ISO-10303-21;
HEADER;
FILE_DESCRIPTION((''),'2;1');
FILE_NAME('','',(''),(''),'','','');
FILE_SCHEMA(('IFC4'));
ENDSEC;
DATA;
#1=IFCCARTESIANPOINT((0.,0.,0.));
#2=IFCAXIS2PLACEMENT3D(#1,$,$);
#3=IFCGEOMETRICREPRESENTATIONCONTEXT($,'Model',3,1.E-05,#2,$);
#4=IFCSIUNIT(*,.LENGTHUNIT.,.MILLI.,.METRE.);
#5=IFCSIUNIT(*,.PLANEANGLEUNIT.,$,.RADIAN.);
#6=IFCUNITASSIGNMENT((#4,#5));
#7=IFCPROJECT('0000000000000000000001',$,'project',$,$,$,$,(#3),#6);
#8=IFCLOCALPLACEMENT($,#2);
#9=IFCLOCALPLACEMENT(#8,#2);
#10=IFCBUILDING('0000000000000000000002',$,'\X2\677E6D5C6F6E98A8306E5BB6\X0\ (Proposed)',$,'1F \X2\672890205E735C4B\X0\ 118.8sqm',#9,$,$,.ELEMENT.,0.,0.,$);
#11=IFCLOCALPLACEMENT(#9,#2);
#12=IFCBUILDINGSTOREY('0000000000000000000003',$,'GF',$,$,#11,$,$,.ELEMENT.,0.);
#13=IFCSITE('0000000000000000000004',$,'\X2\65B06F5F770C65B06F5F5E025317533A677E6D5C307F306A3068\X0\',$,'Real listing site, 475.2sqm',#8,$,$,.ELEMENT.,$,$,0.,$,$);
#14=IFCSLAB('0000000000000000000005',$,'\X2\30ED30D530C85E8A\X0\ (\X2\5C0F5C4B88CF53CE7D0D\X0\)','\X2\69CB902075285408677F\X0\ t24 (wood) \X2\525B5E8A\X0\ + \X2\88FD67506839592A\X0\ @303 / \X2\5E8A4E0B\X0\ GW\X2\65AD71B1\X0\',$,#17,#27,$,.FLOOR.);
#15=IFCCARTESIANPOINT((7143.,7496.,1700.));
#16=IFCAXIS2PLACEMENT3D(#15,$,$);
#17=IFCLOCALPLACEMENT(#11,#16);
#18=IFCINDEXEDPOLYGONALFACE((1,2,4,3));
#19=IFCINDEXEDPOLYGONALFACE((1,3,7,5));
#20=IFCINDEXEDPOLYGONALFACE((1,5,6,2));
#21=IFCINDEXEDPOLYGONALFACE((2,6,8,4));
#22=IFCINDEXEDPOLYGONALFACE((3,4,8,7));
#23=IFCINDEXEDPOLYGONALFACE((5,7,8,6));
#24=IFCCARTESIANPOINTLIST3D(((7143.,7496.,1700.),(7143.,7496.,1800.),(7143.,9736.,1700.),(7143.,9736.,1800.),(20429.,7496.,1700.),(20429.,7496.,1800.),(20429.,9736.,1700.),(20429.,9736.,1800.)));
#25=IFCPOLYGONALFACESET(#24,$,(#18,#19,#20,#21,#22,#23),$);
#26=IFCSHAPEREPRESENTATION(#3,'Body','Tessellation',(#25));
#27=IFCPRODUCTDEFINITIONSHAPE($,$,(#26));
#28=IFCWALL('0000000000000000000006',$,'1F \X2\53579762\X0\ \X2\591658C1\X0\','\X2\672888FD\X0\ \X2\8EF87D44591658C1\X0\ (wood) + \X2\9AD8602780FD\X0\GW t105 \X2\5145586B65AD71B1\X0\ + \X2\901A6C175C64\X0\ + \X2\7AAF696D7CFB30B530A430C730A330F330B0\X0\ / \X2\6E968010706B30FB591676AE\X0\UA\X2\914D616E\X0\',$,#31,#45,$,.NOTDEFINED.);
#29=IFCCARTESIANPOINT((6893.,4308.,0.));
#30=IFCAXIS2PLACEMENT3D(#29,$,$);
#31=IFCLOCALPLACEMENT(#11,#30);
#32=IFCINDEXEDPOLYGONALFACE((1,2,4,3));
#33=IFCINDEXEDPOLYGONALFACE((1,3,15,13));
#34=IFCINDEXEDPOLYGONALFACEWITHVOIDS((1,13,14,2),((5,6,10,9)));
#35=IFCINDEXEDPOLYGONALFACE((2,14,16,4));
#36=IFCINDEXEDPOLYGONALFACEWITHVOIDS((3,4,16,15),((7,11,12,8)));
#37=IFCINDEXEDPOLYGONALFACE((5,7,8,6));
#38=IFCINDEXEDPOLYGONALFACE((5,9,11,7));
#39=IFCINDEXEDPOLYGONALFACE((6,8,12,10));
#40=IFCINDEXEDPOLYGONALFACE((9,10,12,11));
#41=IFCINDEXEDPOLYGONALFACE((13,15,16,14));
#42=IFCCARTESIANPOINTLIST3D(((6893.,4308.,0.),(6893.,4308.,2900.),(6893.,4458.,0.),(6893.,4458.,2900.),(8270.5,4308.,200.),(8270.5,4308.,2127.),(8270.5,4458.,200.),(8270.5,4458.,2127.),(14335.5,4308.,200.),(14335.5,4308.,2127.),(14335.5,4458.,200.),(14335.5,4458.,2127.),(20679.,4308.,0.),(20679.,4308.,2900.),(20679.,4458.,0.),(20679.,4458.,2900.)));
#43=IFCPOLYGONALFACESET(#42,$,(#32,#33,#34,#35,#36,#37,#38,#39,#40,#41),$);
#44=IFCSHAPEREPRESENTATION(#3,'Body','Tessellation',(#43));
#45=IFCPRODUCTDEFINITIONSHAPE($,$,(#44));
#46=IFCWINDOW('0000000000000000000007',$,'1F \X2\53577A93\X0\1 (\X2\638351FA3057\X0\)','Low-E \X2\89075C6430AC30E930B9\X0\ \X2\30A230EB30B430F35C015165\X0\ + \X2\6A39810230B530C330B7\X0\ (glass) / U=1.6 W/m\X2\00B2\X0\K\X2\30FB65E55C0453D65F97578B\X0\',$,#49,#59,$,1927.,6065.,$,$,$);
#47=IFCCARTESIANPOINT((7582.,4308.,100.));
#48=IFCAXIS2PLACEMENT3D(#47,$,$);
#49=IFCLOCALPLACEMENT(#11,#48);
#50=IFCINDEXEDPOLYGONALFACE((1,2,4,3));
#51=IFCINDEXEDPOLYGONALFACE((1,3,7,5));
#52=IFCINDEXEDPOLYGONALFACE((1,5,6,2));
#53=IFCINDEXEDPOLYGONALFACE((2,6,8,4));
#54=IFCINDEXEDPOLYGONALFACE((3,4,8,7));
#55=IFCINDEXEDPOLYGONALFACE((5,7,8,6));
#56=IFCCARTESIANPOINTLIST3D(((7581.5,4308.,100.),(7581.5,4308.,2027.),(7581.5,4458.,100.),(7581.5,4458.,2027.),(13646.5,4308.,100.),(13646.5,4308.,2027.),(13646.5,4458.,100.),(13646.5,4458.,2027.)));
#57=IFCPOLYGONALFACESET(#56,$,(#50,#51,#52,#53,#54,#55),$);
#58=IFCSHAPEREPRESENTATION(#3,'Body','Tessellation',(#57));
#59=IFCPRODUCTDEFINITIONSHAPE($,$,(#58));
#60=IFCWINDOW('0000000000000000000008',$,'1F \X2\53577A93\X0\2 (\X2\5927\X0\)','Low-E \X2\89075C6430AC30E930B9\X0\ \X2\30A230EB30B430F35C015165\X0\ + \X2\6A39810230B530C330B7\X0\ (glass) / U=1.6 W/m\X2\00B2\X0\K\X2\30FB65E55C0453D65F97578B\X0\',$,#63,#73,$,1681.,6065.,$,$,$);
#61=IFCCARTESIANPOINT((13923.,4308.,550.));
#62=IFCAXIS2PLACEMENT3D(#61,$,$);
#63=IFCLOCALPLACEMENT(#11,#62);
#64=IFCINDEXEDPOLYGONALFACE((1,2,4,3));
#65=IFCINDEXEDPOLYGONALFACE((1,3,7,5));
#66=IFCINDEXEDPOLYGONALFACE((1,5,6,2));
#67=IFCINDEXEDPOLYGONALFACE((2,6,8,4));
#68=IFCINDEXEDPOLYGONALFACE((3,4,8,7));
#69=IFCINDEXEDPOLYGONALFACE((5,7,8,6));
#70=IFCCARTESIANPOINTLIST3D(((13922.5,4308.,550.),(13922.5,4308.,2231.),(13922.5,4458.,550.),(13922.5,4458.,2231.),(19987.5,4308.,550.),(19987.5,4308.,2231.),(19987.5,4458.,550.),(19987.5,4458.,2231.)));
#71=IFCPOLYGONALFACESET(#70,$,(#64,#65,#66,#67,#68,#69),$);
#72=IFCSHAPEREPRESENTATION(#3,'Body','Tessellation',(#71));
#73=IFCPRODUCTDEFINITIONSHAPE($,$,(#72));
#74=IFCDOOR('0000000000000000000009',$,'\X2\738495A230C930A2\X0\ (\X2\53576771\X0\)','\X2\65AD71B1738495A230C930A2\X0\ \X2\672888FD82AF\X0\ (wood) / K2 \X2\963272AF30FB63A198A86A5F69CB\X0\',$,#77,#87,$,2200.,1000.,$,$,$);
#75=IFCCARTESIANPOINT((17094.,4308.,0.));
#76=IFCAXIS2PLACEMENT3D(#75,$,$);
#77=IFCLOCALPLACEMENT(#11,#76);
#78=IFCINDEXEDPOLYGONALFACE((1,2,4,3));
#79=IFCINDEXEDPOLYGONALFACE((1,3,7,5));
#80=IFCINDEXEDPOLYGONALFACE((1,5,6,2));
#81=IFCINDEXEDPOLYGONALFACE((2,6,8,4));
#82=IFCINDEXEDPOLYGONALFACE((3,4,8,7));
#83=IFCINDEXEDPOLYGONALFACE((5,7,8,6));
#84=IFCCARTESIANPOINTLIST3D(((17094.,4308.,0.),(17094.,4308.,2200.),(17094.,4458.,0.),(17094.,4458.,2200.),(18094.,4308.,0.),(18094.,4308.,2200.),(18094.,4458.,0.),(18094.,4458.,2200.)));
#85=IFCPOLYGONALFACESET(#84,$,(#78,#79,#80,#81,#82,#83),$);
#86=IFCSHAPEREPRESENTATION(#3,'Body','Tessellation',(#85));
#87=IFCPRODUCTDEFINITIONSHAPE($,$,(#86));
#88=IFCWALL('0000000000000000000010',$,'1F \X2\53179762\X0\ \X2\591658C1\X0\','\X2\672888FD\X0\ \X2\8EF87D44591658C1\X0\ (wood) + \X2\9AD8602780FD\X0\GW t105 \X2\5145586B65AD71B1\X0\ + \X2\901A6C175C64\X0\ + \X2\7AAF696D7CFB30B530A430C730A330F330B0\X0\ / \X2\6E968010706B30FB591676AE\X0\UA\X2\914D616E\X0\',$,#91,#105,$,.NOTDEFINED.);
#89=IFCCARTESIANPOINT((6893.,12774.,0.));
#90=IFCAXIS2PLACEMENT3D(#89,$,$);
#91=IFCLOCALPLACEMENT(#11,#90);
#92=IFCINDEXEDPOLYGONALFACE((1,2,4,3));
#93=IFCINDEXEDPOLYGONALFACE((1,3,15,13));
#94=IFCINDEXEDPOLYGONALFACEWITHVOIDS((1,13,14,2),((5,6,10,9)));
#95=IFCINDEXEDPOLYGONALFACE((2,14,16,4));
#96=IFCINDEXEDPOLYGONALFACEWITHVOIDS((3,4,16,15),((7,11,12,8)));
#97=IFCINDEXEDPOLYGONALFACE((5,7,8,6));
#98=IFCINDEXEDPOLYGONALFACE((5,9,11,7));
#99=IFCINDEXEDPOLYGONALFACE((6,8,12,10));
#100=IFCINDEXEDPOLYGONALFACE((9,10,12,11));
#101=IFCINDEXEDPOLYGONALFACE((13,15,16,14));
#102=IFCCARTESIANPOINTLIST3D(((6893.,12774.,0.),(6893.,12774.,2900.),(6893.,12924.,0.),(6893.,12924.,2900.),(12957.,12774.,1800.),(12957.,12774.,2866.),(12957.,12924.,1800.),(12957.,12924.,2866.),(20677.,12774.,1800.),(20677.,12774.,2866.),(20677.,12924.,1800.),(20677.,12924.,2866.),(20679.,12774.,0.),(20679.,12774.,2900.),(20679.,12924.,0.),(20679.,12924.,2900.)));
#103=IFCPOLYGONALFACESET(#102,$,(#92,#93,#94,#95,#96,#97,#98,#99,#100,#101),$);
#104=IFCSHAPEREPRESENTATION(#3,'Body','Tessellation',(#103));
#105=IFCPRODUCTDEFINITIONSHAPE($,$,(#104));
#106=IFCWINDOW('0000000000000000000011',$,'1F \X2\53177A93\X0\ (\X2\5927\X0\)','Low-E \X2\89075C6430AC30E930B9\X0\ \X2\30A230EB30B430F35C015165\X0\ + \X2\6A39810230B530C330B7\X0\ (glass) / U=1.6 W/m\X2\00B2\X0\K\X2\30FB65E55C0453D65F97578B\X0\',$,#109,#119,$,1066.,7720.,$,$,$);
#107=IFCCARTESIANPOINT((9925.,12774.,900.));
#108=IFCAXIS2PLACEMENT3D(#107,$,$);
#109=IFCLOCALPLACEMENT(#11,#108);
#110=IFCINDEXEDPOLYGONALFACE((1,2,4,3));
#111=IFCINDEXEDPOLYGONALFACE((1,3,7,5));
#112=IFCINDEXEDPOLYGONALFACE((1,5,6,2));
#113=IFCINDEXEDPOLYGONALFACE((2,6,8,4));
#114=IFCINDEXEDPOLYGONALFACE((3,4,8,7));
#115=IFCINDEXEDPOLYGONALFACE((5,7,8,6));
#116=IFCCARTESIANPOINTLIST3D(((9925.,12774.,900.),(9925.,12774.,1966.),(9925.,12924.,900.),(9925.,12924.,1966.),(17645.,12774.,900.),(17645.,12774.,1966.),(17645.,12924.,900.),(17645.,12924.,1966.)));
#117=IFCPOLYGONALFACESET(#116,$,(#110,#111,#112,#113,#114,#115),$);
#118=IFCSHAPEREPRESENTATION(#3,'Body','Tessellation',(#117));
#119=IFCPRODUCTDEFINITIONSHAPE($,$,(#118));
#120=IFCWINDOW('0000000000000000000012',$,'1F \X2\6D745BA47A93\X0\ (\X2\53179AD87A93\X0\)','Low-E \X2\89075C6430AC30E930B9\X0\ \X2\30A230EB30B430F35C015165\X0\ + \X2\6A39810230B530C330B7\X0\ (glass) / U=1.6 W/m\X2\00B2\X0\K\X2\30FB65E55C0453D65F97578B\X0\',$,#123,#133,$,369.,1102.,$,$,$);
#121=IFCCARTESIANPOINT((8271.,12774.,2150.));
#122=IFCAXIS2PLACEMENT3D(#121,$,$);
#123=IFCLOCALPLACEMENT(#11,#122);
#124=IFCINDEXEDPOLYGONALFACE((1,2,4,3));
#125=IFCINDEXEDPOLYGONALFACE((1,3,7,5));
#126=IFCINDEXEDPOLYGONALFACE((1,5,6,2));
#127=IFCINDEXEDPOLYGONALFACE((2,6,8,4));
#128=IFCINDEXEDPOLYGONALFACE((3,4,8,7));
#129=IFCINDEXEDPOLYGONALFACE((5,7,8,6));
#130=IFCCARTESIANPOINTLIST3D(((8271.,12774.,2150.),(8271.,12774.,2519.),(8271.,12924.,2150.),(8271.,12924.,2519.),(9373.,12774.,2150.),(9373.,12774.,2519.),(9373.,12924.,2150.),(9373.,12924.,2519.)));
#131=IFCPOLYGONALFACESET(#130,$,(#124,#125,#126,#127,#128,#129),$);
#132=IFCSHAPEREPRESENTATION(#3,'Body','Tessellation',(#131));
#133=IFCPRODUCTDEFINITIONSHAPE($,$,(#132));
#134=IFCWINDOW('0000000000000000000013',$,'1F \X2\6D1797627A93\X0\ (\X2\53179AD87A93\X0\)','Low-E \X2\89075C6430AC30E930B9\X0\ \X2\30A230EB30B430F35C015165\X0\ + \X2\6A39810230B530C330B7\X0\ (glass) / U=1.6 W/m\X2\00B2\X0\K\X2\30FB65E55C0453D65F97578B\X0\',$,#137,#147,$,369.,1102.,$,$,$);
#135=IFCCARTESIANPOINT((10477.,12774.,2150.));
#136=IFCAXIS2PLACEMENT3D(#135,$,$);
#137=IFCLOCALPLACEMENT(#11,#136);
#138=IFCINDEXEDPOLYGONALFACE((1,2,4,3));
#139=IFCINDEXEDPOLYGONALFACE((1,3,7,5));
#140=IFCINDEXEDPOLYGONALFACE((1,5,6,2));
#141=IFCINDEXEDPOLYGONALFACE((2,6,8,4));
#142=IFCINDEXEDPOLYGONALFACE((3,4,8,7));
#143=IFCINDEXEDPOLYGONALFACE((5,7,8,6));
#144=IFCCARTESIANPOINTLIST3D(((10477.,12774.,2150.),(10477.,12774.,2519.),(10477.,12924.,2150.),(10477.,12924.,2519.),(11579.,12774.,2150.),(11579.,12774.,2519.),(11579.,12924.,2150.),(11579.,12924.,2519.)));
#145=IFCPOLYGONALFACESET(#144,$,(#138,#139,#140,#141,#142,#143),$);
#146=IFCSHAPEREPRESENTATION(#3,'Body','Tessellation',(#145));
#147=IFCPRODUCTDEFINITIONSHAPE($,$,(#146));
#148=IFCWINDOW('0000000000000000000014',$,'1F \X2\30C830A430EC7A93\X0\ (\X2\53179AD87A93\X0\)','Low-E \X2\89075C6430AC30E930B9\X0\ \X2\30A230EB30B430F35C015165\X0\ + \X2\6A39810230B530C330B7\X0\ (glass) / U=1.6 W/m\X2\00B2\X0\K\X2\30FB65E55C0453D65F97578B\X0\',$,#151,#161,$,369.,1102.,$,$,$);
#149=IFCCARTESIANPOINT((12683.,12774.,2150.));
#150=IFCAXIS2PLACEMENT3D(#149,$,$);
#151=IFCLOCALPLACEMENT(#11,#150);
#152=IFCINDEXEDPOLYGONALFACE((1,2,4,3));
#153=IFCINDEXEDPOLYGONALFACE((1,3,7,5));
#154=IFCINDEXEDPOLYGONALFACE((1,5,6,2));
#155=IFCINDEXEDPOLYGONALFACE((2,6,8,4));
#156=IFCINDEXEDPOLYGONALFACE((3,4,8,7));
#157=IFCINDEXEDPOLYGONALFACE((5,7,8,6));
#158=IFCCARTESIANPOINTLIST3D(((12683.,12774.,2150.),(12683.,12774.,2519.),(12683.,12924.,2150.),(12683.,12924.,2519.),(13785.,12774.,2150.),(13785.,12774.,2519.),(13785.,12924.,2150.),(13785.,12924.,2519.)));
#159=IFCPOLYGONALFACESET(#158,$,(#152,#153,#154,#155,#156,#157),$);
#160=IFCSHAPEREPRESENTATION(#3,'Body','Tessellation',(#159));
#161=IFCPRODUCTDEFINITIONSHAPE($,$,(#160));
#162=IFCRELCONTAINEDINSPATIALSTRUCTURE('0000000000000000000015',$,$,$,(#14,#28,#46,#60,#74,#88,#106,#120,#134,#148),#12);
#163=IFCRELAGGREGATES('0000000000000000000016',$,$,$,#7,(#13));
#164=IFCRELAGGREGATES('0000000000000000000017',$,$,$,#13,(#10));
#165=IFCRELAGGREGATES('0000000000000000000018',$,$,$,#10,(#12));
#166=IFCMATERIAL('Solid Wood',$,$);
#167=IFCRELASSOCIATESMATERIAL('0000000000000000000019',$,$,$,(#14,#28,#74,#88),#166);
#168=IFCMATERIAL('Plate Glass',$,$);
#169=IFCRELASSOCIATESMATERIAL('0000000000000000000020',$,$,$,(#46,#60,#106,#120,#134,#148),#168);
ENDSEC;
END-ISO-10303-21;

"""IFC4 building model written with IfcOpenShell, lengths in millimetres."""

from ifc_helpers import new_model, si_unit, frame, frame_2d, origin, place, context, project, spatial, rectangle, extrude, material, element, fill, save


model = new_model("IFC4")

# Units and contexts
model_context = context("Model", 3, precision=1e-05, world=origin())
ifc_project = project(units=[si_unit("LENGTHUNIT", "METRE", prefix="MILLI"), si_unit("PLANEANGLEUNIT", "RADIAN")], contexts=[model_context])

# Site, building, storey
site_placement = place(None, origin())
site = spatial("IfcSite", under=ifc_project, at=site_placement, Name="新潟県新潟市北区松浜みなと", ObjectType="Real listing site, 475.2sqm", CompositionType="ELEMENT", RefElevation=0.0)
building_placement = place(site_placement, origin())
building = spatial("IfcBuilding", under=site, at=building_placement, Name="松浜潮風の家 (Proposed)", ObjectType="1F 木造平屋 118.8sqm", CompositionType="ELEMENT", ElevationOfRefHeight=0.0, ElevationOfTerrain=0.0)
storey_placement = place(building_placement, origin())
storey = spatial("IfcBuildingStorey", under=building, at=storey_placement, Name="GF", CompositionType="ELEMENT", Elevation=0.0)

# Slab
ifc_material_1 = material(Name="Solid Wood")
slab_1_placement = place(storey_placement, frame((7143.0, 7496.0, 1700.0)))
element("IfcSlab", 1, at=slab_1_placement, inside=storey, material=ifc_material_1, Name="ロフト床 (小屋裏収納)", Description="構造用合板 t24 (wood) 剛床 + 製材根太 @303 / 床下 GW断熱", PredefinedType="FLOOR", context=model_context, shape_type="SweptSolid", body=[
    extrude(rectangle(XDim=13286.0, YDim=2240.0, at=frame_2d((6643.0, 1120.0))), frame((7143.0, 7496.0, 1700.0)), (0.0, 0.0, 1.0), 100.0),
])

# Wall, openings, windows, door
wall_1_placement = place(storey_placement, frame((6893.0, 4308.0, 0.0)))
wall_1 = element("IfcWall", 2, at=wall_1_placement, inside=storey, material=ifc_material_1, Name="1F 南面 外壁", Description="木製 軸組外壁 (wood) + 高性能GW t105 充填断熱 + 通気層 + 窯業系サイディング / 準耐火・外皮UA配慮", PredefinedType="NOTDEFINED", context=model_context, shape_type="SweptSolid", body=[
    extrude(rectangle(XDim=13786.0, YDim=150.0, at=frame_2d((6893.0, 75.0))), frame((6893.0, 4308.0, 0.0)), (0.0, 0.0, 1.0), 2900.0),
])
opening_1_placement = place(storey_placement, frame((7582.0, 4308.0, 100.0)))
opening_1 = element("IfcOpeningElement", 3, at=opening_1_placement, cuts=wall_1, PredefinedType="NOTDEFINED", context=model_context, shape_type="SweptSolid", body=[
    extrude(rectangle(XDim=6065.0, YDim=150.0, at=frame_2d((3032.0, 75.0))), frame((7582.0, 4308.0, 100.0)), (0.0, 0.0, 1.0), 1927.0),
])
opening_2_placement = place(storey_placement, frame((13923.0, 4308.0, 550.0)))
opening_2 = element("IfcOpeningElement", 4, at=opening_2_placement, cuts=wall_1, PredefinedType="NOTDEFINED", context=model_context, shape_type="SweptSolid", body=[
    extrude(rectangle(XDim=6065.0, YDim=150.0, at=frame_2d((3032.0, 75.0))), frame((13923.0, 4308.0, 550.0)), (0.0, 0.0, 1.0), 1681.0),
])
opening_3_placement = place(storey_placement, frame((17094.0, 4308.0, 0.0)))
opening_3 = element("IfcOpeningElement", 5, at=opening_3_placement, cuts=wall_1, PredefinedType="NOTDEFINED", context=model_context, shape_type="SweptSolid", body=[
    extrude(rectangle(XDim=1000.0, YDim=150.0, at=frame_2d((500.0, 75.0))), frame((17094.0, 4308.0, 0.0)), (0.0, 0.0, 1.0), 2200.0),
])
ifc_material_2 = material(Name="Plate Glass")
window_1_placement = place(storey_placement, frame((7582.0, 4308.0, 100.0)))
window_1 = element("IfcWindow", 6, at=window_1_placement, inside=storey, material=ifc_material_2, Name="1F 南窓1 (掃出し)", Description="Low-E 複層ガラス アルゴン封入 + 樹脂サッシ (glass) / U=1.6 W/m²K・日射取得型", OverallHeight=1927.0, OverallWidth=6065.0, context=model_context, shape_type="SweptSolid", body=[
    extrude(rectangle(XDim=6065.0, YDim=150.0, at=frame_2d((3032.0, 75.0))), frame((7582.0, 4308.0, 100.0)), (0.0, 0.0, 1.0), 1927.0),
])
fill(opening_1, window_1)
window_2_placement = place(storey_placement, frame((13923.0, 4308.0, 550.0)))
window_2 = element("IfcWindow", 7, at=window_2_placement, inside=storey, material=ifc_material_2, Name="1F 南窓2 (大)", Description="Low-E 複層ガラス アルゴン封入 + 樹脂サッシ (glass) / U=1.6 W/m²K・日射取得型", OverallHeight=1681.0, OverallWidth=6065.0, context=model_context, shape_type="SweptSolid", body=[
    extrude(rectangle(XDim=6065.0, YDim=150.0, at=frame_2d((3032.0, 75.0))), frame((13923.0, 4308.0, 550.0)), (0.0, 0.0, 1.0), 1681.0),
])
fill(opening_2, window_2)
door_1_placement = place(storey_placement, frame((17094.0, 4308.0, 0.0)))
door_1 = element("IfcDoor", 8, at=door_1_placement, inside=storey, material=ifc_material_1, Name="玄関ドア (南東)", Description="断熱玄関ドア 木製芯 (wood) / K2 防犯・採風機構", OverallHeight=2200.0, OverallWidth=1000.0, context=model_context, shape_type="SweptSolid", body=[
    extrude(rectangle(XDim=1000.0, YDim=150.0, at=frame_2d((500.0, 75.0))), frame((17094.0, 4308.0, 0.0)), (0.0, 0.0, 1.0), 2200.0),
])
fill(opening_3, door_1)

# Wall, openings, windows
wall_2_placement = place(storey_placement, frame((6893.0, 12774.0, 0.0)))
wall_2 = element("IfcWall", 9, at=wall_2_placement, inside=storey, material=ifc_material_1, Name="1F 北面 外壁", Description="木製 軸組外壁 (wood) + 高性能GW t105 充填断熱 + 通気層 + 窯業系サイディング / 準耐火・外皮UA配慮", PredefinedType="NOTDEFINED", context=model_context, shape_type="SweptSolid", body=[
    extrude(rectangle(XDim=13786.0, YDim=150.0, at=frame_2d((6893.0, 75.0))), frame((6893.0, 12774.0, 0.0)), (0.0, 0.0, 1.0), 2900.0),
])
opening_4_placement = place(storey_placement, frame((9925.0, 12774.0, 900.0)))
opening_4 = element("IfcOpeningElement", 10, at=opening_4_placement, cuts=wall_2, PredefinedType="NOTDEFINED", context=model_context, shape_type="SweptSolid", body=[
    extrude(rectangle(XDim=7720.0, YDim=150.0, at=frame_2d((3860.0, 75.0))), frame((9925.0, 12774.0, 900.0)), (0.0, 0.0, 1.0), 1066.0),
])
opening_5_placement = place(storey_placement, frame((8271.0, 12774.0, 2150.0)))
opening_5 = element("IfcOpeningElement", 11, at=opening_5_placement, cuts=wall_2, PredefinedType="NOTDEFINED", context=model_context, shape_type="SweptSolid", body=[
    extrude(rectangle(XDim=1102.0, YDim=150.0, at=frame_2d((551.0, 75.0))), frame((8271.0, 12774.0, 2150.0)), (0.0, 0.0, 1.0), 369.0),
])
opening_6_placement = place(storey_placement, frame((10477.0, 12774.0, 2150.0)))
opening_6 = element("IfcOpeningElement", 12, at=opening_6_placement, cuts=wall_2, PredefinedType="NOTDEFINED", context=model_context, shape_type="SweptSolid", body=[
    extrude(rectangle(XDim=1102.0, YDim=150.0, at=frame_2d((551.0, 75.0))), frame((10477.0, 12774.0, 2150.0)), (0.0, 0.0, 1.0), 369.0),
])
opening_7_placement = place(storey_placement, frame((12683.0, 12774.0, 2150.0)))
opening_7 = element("IfcOpeningElement", 13, at=opening_7_placement, cuts=wall_2, PredefinedType="NOTDEFINED", context=model_context, shape_type="SweptSolid", body=[
    extrude(rectangle(XDim=1102.0, YDim=150.0, at=frame_2d((551.0, 75.0))), frame((12683.0, 12774.0, 2150.0)), (0.0, 0.0, 1.0), 369.0),
])
window_3_placement = place(storey_placement, frame((9925.0, 12774.0, 900.0)))
window_3 = element("IfcWindow", 14, at=window_3_placement, inside=storey, material=ifc_material_2, Name="1F 北窓 (大)", Description="Low-E 複層ガラス アルゴン封入 + 樹脂サッシ (glass) / U=1.6 W/m²K・日射取得型", OverallHeight=1066.0, OverallWidth=7720.0, context=model_context, shape_type="SweptSolid", body=[
    extrude(rectangle(XDim=7720.0, YDim=150.0, at=frame_2d((3860.0, 75.0))), frame((9925.0, 12774.0, 900.0)), (0.0, 0.0, 1.0), 1066.0),
])
fill(opening_4, window_3)
window_4_placement = place(storey_placement, frame((8271.0, 12774.0, 2150.0)))
window_4 = element("IfcWindow", 15, at=window_4_placement, inside=storey, material=ifc_material_2, Name="1F 浴室窓 (北高窓)", Description="Low-E 複層ガラス アルゴン封入 + 樹脂サッシ (glass) / U=1.6 W/m²K・日射取得型", OverallHeight=369.0, OverallWidth=1102.0, context=model_context, shape_type="SweptSolid", body=[
    extrude(rectangle(XDim=1102.0, YDim=150.0, at=frame_2d((551.0, 75.0))), frame((8271.0, 12774.0, 2150.0)), (0.0, 0.0, 1.0), 369.0),
])
fill(opening_5, window_4)
window_5_placement = place(storey_placement, frame((10477.0, 12774.0, 2150.0)))
window_5 = element("IfcWindow", 16, at=window_5_placement, inside=storey, material=ifc_material_2, Name="1F 洗面窓 (北高窓)", Description="Low-E 複層ガラス アルゴン封入 + 樹脂サッシ (glass) / U=1.6 W/m²K・日射取得型", OverallHeight=369.0, OverallWidth=1102.0, context=model_context, shape_type="SweptSolid", body=[
    extrude(rectangle(XDim=1102.0, YDim=150.0, at=frame_2d((551.0, 75.0))), frame((10477.0, 12774.0, 2150.0)), (0.0, 0.0, 1.0), 369.0),
])
fill(opening_6, window_5)
window_6_placement = place(storey_placement, frame((12683.0, 12774.0, 2150.0)))
window_6 = element("IfcWindow", 17, at=window_6_placement, inside=storey, material=ifc_material_2, Name="1F トイレ窓 (北高窓)", Description="Low-E 複層ガラス アルゴン封入 + 樹脂サッシ (glass) / U=1.6 W/m²K・日射取得型", OverallHeight=369.0, OverallWidth=1102.0, context=model_context, shape_type="SweptSolid", body=[
    extrude(rectangle(XDim=1102.0, YDim=150.0, at=frame_2d((551.0, 75.0))), frame((12683.0, 12774.0, 2150.0)), (0.0, 0.0, 1.0), 369.0),
])
fill(opening_7, window_6)

save(model, "model.ifc")
